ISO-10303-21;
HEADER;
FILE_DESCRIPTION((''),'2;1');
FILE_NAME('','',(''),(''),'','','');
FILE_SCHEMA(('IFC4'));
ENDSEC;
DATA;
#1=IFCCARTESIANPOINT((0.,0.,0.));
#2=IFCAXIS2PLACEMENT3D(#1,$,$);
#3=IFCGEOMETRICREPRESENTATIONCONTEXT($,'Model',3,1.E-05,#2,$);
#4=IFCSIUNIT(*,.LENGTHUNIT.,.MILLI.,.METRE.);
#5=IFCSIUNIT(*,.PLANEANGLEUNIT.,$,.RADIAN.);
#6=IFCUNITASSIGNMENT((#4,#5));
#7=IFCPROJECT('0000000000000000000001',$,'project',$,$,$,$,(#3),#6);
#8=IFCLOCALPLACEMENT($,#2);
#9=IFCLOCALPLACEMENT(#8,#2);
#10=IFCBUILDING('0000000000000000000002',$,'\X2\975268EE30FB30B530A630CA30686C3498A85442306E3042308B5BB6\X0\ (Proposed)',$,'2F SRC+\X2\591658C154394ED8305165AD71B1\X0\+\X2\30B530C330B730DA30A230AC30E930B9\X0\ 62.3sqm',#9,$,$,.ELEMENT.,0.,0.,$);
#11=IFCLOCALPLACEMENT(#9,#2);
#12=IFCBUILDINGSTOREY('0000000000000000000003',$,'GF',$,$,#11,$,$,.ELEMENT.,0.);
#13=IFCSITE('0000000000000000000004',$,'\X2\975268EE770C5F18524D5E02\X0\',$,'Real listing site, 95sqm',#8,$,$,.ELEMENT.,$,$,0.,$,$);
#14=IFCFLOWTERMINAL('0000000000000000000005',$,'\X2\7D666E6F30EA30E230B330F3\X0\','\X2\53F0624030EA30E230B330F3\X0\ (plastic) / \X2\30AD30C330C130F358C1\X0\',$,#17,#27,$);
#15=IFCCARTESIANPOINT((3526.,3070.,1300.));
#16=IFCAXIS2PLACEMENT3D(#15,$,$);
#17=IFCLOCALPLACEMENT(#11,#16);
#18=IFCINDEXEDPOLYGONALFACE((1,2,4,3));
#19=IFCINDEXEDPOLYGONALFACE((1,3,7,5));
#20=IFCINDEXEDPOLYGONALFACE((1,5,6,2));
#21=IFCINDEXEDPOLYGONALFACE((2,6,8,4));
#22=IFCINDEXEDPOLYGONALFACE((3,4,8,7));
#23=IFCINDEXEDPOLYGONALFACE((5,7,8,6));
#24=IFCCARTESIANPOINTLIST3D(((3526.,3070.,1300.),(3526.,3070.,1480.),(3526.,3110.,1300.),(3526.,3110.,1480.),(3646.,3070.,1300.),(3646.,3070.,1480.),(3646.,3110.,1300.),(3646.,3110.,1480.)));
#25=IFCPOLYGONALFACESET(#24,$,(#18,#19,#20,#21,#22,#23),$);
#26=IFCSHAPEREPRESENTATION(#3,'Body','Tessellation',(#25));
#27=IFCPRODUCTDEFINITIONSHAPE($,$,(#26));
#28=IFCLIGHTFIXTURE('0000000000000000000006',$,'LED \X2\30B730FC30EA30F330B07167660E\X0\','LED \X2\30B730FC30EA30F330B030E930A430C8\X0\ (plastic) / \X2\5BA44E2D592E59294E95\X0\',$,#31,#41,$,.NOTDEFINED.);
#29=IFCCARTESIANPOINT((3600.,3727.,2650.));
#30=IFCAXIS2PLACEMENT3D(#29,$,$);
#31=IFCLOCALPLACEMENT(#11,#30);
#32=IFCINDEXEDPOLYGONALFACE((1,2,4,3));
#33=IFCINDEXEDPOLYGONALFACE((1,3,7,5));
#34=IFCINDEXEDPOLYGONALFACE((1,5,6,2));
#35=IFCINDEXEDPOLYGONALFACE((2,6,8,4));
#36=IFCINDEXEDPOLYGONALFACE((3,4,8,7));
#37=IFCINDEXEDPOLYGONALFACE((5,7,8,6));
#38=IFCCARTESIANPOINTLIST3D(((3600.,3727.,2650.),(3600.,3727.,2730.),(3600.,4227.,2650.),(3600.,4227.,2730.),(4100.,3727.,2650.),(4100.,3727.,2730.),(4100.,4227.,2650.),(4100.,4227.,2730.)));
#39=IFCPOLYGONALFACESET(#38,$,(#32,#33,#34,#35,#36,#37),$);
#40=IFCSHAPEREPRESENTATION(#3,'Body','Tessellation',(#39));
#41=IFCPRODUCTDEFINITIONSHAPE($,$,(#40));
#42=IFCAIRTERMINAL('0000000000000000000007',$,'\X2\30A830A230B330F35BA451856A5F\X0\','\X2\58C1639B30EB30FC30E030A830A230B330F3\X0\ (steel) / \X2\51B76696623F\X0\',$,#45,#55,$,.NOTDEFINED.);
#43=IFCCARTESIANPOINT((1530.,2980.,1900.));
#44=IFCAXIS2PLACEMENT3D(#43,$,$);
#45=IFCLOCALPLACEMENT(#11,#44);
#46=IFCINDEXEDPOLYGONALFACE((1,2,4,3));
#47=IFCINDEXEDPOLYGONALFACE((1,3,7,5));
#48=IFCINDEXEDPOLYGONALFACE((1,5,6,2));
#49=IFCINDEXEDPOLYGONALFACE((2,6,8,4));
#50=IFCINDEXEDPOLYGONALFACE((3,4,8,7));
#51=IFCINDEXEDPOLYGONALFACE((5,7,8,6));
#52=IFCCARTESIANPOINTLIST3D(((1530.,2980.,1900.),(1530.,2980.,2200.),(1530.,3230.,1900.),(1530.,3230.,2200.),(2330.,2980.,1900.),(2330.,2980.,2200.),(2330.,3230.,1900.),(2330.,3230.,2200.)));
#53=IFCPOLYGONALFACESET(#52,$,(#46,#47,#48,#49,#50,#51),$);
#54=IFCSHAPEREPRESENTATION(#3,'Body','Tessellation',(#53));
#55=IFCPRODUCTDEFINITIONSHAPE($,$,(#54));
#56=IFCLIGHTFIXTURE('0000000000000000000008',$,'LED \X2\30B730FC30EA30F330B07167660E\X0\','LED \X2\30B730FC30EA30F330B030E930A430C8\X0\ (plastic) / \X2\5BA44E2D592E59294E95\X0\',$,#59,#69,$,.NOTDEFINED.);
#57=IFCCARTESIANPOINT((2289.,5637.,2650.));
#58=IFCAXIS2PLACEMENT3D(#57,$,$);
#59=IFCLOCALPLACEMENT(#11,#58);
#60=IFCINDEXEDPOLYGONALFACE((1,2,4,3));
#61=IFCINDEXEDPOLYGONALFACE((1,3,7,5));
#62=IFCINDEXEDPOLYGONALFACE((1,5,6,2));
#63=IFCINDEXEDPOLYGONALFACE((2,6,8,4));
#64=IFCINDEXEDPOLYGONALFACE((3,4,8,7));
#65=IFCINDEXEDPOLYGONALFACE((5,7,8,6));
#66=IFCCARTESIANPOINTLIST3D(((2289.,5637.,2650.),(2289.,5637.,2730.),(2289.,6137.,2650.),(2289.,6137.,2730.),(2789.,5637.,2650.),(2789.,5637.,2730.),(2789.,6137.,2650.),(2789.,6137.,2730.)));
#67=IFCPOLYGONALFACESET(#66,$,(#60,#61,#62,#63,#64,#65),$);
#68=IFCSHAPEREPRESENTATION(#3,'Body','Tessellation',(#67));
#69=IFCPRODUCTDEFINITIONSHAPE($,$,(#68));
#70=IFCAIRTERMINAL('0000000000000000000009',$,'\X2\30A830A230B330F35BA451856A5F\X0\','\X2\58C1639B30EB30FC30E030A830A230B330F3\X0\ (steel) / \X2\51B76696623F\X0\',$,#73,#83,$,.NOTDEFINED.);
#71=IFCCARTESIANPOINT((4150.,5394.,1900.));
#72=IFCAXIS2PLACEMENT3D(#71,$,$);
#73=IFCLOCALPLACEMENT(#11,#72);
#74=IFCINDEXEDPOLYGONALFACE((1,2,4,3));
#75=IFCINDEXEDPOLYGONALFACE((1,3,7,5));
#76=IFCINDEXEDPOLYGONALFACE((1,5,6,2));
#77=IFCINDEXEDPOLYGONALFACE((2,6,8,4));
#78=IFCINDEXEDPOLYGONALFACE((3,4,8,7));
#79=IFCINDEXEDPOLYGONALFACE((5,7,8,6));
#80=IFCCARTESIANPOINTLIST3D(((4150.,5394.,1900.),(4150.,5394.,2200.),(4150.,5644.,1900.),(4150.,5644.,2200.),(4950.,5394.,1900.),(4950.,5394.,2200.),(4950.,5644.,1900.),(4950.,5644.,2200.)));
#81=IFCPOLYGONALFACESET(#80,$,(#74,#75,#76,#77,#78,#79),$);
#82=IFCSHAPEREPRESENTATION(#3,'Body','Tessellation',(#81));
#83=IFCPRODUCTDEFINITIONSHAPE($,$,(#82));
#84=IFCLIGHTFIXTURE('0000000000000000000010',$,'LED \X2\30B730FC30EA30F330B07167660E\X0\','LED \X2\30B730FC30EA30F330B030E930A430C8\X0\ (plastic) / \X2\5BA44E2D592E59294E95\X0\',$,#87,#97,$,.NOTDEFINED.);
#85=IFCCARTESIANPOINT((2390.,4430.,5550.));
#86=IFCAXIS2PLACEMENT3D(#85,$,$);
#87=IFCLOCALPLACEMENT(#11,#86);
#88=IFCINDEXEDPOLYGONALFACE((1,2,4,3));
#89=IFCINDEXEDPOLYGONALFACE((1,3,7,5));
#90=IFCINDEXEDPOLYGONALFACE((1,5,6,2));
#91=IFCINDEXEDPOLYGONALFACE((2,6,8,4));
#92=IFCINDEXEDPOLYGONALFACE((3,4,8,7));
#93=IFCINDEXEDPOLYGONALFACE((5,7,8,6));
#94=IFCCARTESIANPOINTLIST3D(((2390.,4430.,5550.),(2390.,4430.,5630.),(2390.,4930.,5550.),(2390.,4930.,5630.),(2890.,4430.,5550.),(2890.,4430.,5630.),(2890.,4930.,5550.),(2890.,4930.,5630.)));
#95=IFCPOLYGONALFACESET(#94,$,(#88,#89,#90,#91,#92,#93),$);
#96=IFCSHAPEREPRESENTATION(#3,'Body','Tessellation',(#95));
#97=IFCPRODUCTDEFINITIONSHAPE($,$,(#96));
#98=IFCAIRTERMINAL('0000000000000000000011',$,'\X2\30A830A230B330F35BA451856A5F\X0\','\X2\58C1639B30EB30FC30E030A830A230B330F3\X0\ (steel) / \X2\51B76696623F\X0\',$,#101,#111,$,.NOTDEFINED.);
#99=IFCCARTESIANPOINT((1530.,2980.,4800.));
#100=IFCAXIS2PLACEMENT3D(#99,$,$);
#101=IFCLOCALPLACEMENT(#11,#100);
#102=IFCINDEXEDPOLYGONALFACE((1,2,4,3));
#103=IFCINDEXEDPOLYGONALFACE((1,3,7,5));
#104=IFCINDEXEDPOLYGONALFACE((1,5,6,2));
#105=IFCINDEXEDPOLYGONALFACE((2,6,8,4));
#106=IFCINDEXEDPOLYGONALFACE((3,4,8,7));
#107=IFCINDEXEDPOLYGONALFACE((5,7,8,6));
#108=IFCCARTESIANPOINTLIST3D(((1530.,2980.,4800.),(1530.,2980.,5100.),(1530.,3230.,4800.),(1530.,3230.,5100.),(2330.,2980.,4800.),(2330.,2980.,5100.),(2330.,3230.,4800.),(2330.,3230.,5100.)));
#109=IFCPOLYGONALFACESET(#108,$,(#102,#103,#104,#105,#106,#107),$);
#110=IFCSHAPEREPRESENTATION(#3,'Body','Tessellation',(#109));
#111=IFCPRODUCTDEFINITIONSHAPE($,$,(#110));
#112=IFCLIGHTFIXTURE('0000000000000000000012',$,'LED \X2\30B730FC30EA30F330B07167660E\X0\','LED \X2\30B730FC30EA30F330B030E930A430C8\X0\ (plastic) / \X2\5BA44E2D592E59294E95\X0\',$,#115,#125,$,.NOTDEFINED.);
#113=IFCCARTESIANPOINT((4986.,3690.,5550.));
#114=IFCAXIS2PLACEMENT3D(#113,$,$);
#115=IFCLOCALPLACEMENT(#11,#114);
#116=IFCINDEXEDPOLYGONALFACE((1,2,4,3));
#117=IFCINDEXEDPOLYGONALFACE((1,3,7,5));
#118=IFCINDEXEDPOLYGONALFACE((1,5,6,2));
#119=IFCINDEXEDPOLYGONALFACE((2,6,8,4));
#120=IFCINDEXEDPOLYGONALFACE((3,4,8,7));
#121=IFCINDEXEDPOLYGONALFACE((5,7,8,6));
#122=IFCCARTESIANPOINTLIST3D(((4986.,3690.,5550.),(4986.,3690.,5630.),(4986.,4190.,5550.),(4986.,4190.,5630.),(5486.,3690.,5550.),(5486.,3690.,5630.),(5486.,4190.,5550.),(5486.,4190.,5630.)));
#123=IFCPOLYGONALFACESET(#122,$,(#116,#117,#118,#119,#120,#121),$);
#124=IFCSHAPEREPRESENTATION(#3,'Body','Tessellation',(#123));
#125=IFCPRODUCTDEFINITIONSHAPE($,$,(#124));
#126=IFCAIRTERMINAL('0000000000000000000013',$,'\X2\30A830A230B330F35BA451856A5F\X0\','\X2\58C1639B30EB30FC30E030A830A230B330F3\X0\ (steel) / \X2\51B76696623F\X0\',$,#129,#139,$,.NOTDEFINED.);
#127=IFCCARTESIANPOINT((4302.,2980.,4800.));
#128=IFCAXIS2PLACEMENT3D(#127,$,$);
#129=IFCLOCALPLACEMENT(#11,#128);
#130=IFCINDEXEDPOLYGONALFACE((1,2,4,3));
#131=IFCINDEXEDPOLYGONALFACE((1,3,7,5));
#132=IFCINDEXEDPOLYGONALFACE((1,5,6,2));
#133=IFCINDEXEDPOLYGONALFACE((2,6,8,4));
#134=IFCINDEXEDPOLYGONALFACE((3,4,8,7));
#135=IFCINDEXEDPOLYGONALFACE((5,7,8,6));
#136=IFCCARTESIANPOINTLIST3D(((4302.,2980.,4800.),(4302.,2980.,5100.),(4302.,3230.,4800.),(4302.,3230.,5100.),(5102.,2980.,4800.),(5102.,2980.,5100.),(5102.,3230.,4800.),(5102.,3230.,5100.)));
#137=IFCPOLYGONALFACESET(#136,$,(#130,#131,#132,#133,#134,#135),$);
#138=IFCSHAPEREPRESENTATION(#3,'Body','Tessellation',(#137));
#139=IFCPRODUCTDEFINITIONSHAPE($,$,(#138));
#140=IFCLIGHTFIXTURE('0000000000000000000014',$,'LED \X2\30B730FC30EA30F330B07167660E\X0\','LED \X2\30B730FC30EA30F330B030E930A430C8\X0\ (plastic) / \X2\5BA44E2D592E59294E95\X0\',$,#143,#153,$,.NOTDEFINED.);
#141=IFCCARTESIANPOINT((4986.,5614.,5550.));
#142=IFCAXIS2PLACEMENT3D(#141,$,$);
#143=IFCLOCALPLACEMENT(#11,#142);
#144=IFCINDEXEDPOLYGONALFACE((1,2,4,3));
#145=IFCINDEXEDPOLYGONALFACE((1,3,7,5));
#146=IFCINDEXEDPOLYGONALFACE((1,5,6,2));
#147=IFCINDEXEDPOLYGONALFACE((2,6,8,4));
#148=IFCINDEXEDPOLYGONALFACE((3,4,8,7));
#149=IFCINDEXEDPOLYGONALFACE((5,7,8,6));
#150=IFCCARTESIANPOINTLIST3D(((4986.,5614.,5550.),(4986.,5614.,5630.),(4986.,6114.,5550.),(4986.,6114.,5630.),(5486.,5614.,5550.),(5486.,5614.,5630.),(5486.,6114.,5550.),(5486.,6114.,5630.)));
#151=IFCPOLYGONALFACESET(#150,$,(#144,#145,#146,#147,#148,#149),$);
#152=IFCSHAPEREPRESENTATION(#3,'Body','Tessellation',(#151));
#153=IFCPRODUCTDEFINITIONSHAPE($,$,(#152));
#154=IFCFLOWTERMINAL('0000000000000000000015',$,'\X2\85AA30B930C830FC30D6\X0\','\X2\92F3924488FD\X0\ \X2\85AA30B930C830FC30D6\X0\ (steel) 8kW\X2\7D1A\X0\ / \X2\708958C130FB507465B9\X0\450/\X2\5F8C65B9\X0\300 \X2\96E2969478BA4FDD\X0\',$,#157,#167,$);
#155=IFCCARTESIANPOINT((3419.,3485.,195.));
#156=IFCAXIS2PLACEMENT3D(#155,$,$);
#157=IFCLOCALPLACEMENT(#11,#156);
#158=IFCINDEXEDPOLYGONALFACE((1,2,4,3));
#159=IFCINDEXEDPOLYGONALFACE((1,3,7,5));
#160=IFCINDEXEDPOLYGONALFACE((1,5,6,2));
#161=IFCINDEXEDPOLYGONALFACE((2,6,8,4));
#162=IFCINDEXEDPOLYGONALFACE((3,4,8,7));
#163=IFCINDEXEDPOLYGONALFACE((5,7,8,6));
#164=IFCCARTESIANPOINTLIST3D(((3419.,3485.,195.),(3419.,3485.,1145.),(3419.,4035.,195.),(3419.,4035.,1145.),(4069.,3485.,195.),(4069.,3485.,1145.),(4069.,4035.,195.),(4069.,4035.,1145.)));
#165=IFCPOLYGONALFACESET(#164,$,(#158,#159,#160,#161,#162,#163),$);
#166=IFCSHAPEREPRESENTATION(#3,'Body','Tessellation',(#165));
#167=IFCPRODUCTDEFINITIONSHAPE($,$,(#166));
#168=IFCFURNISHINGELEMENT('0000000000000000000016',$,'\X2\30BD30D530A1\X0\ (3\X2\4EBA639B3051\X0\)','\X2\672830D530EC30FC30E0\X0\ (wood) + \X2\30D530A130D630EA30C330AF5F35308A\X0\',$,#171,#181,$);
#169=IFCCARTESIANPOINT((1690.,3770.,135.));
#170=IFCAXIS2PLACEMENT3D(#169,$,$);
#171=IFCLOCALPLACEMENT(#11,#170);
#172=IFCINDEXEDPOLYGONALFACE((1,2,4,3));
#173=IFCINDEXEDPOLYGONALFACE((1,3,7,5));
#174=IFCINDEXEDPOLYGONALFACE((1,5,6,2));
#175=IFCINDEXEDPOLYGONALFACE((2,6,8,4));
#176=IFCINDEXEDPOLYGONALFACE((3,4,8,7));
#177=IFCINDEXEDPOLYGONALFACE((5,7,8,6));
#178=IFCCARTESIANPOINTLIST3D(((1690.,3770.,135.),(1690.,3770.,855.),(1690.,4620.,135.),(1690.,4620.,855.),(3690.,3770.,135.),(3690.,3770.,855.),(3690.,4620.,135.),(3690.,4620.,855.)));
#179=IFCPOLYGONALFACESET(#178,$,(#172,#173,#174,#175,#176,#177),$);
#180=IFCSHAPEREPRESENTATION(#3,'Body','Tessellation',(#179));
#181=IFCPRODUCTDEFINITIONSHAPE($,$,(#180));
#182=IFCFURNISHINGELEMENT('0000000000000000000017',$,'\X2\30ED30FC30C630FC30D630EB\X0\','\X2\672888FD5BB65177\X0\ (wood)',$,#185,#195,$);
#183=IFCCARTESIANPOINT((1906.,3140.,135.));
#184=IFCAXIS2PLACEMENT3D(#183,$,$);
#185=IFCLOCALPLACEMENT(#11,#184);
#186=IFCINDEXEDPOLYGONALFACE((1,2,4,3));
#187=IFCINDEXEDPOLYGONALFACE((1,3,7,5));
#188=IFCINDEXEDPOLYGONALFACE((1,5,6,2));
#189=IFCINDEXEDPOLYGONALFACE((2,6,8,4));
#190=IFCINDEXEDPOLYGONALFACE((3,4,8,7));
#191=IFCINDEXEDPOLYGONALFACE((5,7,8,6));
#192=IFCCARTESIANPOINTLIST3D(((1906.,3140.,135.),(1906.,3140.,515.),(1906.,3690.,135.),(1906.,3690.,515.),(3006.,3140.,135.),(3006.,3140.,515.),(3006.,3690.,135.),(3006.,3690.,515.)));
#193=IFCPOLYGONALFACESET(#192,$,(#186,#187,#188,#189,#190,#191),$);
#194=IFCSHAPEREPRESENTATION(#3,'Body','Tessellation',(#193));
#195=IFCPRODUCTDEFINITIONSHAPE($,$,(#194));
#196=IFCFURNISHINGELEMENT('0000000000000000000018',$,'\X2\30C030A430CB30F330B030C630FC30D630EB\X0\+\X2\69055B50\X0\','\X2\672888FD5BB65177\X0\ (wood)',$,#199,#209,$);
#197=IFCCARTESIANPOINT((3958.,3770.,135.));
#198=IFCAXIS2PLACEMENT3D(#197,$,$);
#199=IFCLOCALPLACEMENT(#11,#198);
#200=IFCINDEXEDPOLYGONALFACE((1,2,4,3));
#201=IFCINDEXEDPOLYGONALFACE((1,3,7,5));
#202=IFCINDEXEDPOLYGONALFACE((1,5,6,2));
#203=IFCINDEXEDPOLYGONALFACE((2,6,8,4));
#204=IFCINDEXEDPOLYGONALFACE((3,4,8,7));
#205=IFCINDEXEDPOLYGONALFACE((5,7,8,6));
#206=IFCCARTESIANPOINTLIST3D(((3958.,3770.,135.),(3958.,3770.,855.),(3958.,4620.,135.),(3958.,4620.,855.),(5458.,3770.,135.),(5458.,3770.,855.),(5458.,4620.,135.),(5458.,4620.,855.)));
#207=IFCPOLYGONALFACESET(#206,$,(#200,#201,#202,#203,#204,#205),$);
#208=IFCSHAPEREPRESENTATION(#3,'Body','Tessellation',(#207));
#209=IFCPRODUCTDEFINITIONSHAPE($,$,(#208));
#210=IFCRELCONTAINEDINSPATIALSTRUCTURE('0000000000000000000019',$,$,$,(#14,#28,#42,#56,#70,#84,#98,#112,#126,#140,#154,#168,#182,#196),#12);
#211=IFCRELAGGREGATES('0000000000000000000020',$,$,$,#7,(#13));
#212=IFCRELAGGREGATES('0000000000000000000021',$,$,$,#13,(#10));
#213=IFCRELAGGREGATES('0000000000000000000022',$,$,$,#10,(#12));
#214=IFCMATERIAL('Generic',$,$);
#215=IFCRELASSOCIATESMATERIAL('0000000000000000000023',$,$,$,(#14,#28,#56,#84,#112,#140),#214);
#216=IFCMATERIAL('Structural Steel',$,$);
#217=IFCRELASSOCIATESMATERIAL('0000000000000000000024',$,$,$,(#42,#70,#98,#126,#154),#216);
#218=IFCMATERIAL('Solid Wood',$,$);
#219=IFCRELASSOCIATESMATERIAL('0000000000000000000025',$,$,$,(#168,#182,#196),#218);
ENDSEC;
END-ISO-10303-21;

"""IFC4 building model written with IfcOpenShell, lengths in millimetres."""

from ifc_helpers import new_model, si_unit, frame, frame_2d, origin, place, context, project, spatial, rectangle, extrude, material, element, save


model = new_model("IFC4")

# Units and contexts
model_context = context("Model", 3, precision=1e-05, world=origin())
ifc_project = project(units=[si_unit("LENGTHUNIT", "METRE", prefix="MILLI"), si_unit("PLANEANGLEUNIT", "RADIAN")], contexts=[model_context])

# Site, building, storey
site_placement = place(None, origin())
site = spatial("IfcSite", under=ifc_project, at=site_placement, Name="青森県弘前市", ObjectType="Real listing site, 95sqm", CompositionType="ELEMENT", RefElevation=0.0)
building_placement = place(site_placement, origin())
building = spatial("IfcBuilding", under=site, at=building_placement, Name="青森・サウナと水風呂のある家 (Proposed)", ObjectType="2F SRC+外壁吹付け断熱+サッシペアガラス 62.3sqm", CompositionType="ELEMENT", ElevationOfRefHeight=0.0, ElevationOfTerrain=0.0)
storey_placement = place(building_placement, origin())
storey = spatial("IfcBuildingStorey", under=building, at=storey_placement, Name="GF", CompositionType="ELEMENT", Elevation=0.0)

# Shared definitions
ifc_material_1 = material(Name="Solid Wood")

# Shared definitions
ifc_material_2 = material(Name="Structural Steel")

# Flow terminal
ifc_material_3 = material(Name="Generic")
flow_terminal_1_placement = place(storey_placement, frame((3526.0, 3070.0, 1300.0)))
element("IfcFlowTerminal", 1, at=flow_terminal_1_placement, inside=storey, material=ifc_material_3, Name="給湯リモコン", Description="台所リモコン (plastic) / キッチン壁", context=model_context, shape_type="SweptSolid", body=[
    extrude(rectangle(XDim=120.0, YDim=40.0, at=frame_2d((60.0, 20.0))), frame((3526.0, 3070.0, 1300.0)), (0.0, 0.0, 1.0), 180.0),
])

# Light fixture
light_fixture_1_placement = place(storey_placement, frame((3600.0, 3727.0, 2650.0)))
element("IfcLightFixture", 2, at=light_fixture_1_placement, inside=storey, material=ifc_material_3, Name="LED シーリング照明", Description="LED シーリングライト (plastic) / 室中央天井", PredefinedType="NOTDEFINED", context=model_context, shape_type="SweptSolid", body=[
    extrude(rectangle(XDim=500.0, YDim=500.0, at=frame_2d((250.0, 250.0))), frame((3600.0, 3727.0, 2650.0)), (0.0, 0.0, 1.0), 80.0),
])

# Air terminal
air_terminal_1_placement = place(storey_placement, frame((1530.0, 2980.0, 1900.0)))
element("IfcAirTerminal", 3, at=air_terminal_1_placement, inside=storey, material=ifc_material_2, Name="エアコン室内機", Description="壁掛ルームエアコン (steel) / 冷暖房", PredefinedType="NOTDEFINED", context=model_context, shape_type="SweptSolid", body=[
    extrude(rectangle(XDim=800.0, YDim=250.0, at=frame_2d((400.0, 125.0))), frame((1530.0, 2980.0, 1900.0)), (0.0, 0.0, 1.0), 300.0),
])

# Light fixture
light_fixture_2_placement = place(storey_placement, frame((2289.0, 5637.0, 2650.0)))
element("IfcLightFixture", 4, at=light_fixture_2_placement, inside=storey, material=ifc_material_3, Name="LED シーリング照明", Description="LED シーリングライト (plastic) / 室中央天井", PredefinedType="NOTDEFINED", context=model_context, shape_type="SweptSolid", body=[
    extrude(rectangle(XDim=500.0, YDim=500.0, at=frame_2d((250.0, 250.0))), frame((2289.0, 5637.0, 2650.0)), (0.0, 0.0, 1.0), 80.0),
])

# Air terminal
air_terminal_2_placement = place(storey_placement, frame((4150.0, 5394.0, 1900.0)))
element("IfcAirTerminal", 5, at=air_terminal_2_placement, inside=storey, material=ifc_material_2, Name="エアコン室内機", Description="壁掛ルームエアコン (steel) / 冷暖房", PredefinedType="NOTDEFINED", context=model_context, shape_type="SweptSolid", body=[
    extrude(rectangle(XDim=800.0, YDim=250.0, at=frame_2d((400.0, 125.0))), frame((4150.0, 5394.0, 1900.0)), (0.0, 0.0, 1.0), 300.0),
])

# Light fixture
light_fixture_3_placement = place(storey_placement, frame((2390.0, 4430.0, 5550.0)))
element("IfcLightFixture", 6, at=light_fixture_3_placement, inside=storey, material=ifc_material_3, Name="LED シーリング照明", Description="LED シーリングライト (plastic) / 室中央天井", PredefinedType="NOTDEFINED", context=model_context, shape_type="SweptSolid", body=[
    extrude(rectangle(XDim=500.0, YDim=500.0, at=frame_2d((250.0, 250.0))), frame((2390.0, 4430.0, 5550.0)), (0.0, 0.0, 1.0), 80.0),
])

# Air terminal
air_terminal_3_placement = place(storey_placement, frame((1530.0, 2980.0, 4800.0)))
element("IfcAirTerminal", 7, at=air_terminal_3_placement, inside=storey, material=ifc_material_2, Name="エアコン室内機", Description="壁掛ルームエアコン (steel) / 冷暖房", PredefinedType="NOTDEFINED", context=model_context, shape_type="SweptSolid", body=[
    extrude(rectangle(XDim=800.0, YDim=250.0, at=frame_2d((400.0, 125.0))), frame((1530.0, 2980.0, 4800.0)), (0.0, 0.0, 1.0), 300.0),
])

# Light fixture
light_fixture_4_placement = place(storey_placement, frame((4986.0, 3690.0, 5550.0)))
element("IfcLightFixture", 8, at=light_fixture_4_placement, inside=storey, material=ifc_material_3, Name="LED シーリング照明", Description="LED シーリングライト (plastic) / 室中央天井", PredefinedType="NOTDEFINED", context=model_context, shape_type="SweptSolid", body=[
    extrude(rectangle(XDim=500.0, YDim=500.0, at=frame_2d((250.0, 250.0))), frame((4986.0, 3690.0, 5550.0)), (0.0, 0.0, 1.0), 80.0),
])

# Air terminal
air_terminal_4_placement = place(storey_placement, frame((4302.0, 2980.0, 4800.0)))
element("IfcAirTerminal", 9, at=air_terminal_4_placement, inside=storey, material=ifc_material_2, Name="エアコン室内機", Description="壁掛ルームエアコン (steel) / 冷暖房", PredefinedType="NOTDEFINED", context=model_context, shape_type="SweptSolid", body=[
    extrude(rectangle(XDim=800.0, YDim=250.0, at=frame_2d((400.0, 125.0))), frame((4302.0, 2980.0, 4800.0)), (0.0, 0.0, 1.0), 300.0),
])

# Light fixture
light_fixture_5_placement = place(storey_placement, frame((4986.0, 5614.0, 5550.0)))
element("IfcLightFixture", 10, at=light_fixture_5_placement, inside=storey, material=ifc_material_3, Name="LED シーリング照明", Description="LED シーリングライト (plastic) / 室中央天井", PredefinedType="NOTDEFINED", context=model_context, shape_type="SweptSolid", body=[
    extrude(rectangle(XDim=500.0, YDim=500.0, at=frame_2d((250.0, 250.0))), frame((4986.0, 5614.0, 5550.0)), (0.0, 0.0, 1.0), 80.0),
])

# Flow terminal
flow_terminal_2_placement = place(storey_placement, frame((3419.0, 3485.0, 195.0)))
element("IfcFlowTerminal", 11, at=flow_terminal_2_placement, inside=storey, material=ifc_material_2, Name="薪ストーブ", Description="鋳鉄製 薪ストーブ (steel) 8kW級 / 炉壁・側方450/後方300 離隔確保", context=model_context, shape_type="SweptSolid", body=[
    extrude(rectangle(XDim=650.0, YDim=550.0, at=frame_2d((325.0, 275.0))), frame((3419.0, 3485.0, 195.0)), (0.0, 0.0, 1.0), 950.0),
])

# Furnishing elements
furnishing_1_placement = place(storey_placement, frame((1690.0, 3770.0, 135.0)))
element("IfcFurnishingElement", 12, at=furnishing_1_placement, inside=storey, material=ifc_material_1, Name="ソファ (3人掛け)", Description="木フレーム (wood) + ファブリック張り", context=model_context, shape_type="SweptSolid", body=[
    extrude(rectangle(XDim=2000.0, YDim=850.0, at=frame_2d((1000.0, 425.0))), frame((1690.0, 3770.0, 135.0)), (0.0, 0.0, 1.0), 720.0),
])
furnishing_2_placement = place(storey_placement, frame((1906.0, 3140.0, 135.0)))
element("IfcFurnishingElement", 13, at=furnishing_2_placement, inside=storey, material=ifc_material_1, Name="ローテーブル", Description="木製家具 (wood)", context=model_context, shape_type="SweptSolid", body=[
    extrude(rectangle(XDim=1100.0, YDim=550.0, at=frame_2d((550.0, 275.0))), frame((1906.0, 3140.0, 135.0)), (0.0, 0.0, 1.0), 380.0),
])
furnishing_3_placement = place(storey_placement, frame((3958.0, 3770.0, 135.0)))
element("IfcFurnishingElement", 14, at=furnishing_3_placement, inside=storey, material=ifc_material_1, Name="ダイニングテーブル+椅子", Description="木製家具 (wood)", context=model_context, shape_type="SweptSolid", body=[
    extrude(rectangle(XDim=1500.0, YDim=850.0, at=frame_2d((750.0, 425.0))), frame((3958.0, 3770.0, 135.0)), (0.0, 0.0, 1.0), 720.0),
])

save(model, "model.ifc")
